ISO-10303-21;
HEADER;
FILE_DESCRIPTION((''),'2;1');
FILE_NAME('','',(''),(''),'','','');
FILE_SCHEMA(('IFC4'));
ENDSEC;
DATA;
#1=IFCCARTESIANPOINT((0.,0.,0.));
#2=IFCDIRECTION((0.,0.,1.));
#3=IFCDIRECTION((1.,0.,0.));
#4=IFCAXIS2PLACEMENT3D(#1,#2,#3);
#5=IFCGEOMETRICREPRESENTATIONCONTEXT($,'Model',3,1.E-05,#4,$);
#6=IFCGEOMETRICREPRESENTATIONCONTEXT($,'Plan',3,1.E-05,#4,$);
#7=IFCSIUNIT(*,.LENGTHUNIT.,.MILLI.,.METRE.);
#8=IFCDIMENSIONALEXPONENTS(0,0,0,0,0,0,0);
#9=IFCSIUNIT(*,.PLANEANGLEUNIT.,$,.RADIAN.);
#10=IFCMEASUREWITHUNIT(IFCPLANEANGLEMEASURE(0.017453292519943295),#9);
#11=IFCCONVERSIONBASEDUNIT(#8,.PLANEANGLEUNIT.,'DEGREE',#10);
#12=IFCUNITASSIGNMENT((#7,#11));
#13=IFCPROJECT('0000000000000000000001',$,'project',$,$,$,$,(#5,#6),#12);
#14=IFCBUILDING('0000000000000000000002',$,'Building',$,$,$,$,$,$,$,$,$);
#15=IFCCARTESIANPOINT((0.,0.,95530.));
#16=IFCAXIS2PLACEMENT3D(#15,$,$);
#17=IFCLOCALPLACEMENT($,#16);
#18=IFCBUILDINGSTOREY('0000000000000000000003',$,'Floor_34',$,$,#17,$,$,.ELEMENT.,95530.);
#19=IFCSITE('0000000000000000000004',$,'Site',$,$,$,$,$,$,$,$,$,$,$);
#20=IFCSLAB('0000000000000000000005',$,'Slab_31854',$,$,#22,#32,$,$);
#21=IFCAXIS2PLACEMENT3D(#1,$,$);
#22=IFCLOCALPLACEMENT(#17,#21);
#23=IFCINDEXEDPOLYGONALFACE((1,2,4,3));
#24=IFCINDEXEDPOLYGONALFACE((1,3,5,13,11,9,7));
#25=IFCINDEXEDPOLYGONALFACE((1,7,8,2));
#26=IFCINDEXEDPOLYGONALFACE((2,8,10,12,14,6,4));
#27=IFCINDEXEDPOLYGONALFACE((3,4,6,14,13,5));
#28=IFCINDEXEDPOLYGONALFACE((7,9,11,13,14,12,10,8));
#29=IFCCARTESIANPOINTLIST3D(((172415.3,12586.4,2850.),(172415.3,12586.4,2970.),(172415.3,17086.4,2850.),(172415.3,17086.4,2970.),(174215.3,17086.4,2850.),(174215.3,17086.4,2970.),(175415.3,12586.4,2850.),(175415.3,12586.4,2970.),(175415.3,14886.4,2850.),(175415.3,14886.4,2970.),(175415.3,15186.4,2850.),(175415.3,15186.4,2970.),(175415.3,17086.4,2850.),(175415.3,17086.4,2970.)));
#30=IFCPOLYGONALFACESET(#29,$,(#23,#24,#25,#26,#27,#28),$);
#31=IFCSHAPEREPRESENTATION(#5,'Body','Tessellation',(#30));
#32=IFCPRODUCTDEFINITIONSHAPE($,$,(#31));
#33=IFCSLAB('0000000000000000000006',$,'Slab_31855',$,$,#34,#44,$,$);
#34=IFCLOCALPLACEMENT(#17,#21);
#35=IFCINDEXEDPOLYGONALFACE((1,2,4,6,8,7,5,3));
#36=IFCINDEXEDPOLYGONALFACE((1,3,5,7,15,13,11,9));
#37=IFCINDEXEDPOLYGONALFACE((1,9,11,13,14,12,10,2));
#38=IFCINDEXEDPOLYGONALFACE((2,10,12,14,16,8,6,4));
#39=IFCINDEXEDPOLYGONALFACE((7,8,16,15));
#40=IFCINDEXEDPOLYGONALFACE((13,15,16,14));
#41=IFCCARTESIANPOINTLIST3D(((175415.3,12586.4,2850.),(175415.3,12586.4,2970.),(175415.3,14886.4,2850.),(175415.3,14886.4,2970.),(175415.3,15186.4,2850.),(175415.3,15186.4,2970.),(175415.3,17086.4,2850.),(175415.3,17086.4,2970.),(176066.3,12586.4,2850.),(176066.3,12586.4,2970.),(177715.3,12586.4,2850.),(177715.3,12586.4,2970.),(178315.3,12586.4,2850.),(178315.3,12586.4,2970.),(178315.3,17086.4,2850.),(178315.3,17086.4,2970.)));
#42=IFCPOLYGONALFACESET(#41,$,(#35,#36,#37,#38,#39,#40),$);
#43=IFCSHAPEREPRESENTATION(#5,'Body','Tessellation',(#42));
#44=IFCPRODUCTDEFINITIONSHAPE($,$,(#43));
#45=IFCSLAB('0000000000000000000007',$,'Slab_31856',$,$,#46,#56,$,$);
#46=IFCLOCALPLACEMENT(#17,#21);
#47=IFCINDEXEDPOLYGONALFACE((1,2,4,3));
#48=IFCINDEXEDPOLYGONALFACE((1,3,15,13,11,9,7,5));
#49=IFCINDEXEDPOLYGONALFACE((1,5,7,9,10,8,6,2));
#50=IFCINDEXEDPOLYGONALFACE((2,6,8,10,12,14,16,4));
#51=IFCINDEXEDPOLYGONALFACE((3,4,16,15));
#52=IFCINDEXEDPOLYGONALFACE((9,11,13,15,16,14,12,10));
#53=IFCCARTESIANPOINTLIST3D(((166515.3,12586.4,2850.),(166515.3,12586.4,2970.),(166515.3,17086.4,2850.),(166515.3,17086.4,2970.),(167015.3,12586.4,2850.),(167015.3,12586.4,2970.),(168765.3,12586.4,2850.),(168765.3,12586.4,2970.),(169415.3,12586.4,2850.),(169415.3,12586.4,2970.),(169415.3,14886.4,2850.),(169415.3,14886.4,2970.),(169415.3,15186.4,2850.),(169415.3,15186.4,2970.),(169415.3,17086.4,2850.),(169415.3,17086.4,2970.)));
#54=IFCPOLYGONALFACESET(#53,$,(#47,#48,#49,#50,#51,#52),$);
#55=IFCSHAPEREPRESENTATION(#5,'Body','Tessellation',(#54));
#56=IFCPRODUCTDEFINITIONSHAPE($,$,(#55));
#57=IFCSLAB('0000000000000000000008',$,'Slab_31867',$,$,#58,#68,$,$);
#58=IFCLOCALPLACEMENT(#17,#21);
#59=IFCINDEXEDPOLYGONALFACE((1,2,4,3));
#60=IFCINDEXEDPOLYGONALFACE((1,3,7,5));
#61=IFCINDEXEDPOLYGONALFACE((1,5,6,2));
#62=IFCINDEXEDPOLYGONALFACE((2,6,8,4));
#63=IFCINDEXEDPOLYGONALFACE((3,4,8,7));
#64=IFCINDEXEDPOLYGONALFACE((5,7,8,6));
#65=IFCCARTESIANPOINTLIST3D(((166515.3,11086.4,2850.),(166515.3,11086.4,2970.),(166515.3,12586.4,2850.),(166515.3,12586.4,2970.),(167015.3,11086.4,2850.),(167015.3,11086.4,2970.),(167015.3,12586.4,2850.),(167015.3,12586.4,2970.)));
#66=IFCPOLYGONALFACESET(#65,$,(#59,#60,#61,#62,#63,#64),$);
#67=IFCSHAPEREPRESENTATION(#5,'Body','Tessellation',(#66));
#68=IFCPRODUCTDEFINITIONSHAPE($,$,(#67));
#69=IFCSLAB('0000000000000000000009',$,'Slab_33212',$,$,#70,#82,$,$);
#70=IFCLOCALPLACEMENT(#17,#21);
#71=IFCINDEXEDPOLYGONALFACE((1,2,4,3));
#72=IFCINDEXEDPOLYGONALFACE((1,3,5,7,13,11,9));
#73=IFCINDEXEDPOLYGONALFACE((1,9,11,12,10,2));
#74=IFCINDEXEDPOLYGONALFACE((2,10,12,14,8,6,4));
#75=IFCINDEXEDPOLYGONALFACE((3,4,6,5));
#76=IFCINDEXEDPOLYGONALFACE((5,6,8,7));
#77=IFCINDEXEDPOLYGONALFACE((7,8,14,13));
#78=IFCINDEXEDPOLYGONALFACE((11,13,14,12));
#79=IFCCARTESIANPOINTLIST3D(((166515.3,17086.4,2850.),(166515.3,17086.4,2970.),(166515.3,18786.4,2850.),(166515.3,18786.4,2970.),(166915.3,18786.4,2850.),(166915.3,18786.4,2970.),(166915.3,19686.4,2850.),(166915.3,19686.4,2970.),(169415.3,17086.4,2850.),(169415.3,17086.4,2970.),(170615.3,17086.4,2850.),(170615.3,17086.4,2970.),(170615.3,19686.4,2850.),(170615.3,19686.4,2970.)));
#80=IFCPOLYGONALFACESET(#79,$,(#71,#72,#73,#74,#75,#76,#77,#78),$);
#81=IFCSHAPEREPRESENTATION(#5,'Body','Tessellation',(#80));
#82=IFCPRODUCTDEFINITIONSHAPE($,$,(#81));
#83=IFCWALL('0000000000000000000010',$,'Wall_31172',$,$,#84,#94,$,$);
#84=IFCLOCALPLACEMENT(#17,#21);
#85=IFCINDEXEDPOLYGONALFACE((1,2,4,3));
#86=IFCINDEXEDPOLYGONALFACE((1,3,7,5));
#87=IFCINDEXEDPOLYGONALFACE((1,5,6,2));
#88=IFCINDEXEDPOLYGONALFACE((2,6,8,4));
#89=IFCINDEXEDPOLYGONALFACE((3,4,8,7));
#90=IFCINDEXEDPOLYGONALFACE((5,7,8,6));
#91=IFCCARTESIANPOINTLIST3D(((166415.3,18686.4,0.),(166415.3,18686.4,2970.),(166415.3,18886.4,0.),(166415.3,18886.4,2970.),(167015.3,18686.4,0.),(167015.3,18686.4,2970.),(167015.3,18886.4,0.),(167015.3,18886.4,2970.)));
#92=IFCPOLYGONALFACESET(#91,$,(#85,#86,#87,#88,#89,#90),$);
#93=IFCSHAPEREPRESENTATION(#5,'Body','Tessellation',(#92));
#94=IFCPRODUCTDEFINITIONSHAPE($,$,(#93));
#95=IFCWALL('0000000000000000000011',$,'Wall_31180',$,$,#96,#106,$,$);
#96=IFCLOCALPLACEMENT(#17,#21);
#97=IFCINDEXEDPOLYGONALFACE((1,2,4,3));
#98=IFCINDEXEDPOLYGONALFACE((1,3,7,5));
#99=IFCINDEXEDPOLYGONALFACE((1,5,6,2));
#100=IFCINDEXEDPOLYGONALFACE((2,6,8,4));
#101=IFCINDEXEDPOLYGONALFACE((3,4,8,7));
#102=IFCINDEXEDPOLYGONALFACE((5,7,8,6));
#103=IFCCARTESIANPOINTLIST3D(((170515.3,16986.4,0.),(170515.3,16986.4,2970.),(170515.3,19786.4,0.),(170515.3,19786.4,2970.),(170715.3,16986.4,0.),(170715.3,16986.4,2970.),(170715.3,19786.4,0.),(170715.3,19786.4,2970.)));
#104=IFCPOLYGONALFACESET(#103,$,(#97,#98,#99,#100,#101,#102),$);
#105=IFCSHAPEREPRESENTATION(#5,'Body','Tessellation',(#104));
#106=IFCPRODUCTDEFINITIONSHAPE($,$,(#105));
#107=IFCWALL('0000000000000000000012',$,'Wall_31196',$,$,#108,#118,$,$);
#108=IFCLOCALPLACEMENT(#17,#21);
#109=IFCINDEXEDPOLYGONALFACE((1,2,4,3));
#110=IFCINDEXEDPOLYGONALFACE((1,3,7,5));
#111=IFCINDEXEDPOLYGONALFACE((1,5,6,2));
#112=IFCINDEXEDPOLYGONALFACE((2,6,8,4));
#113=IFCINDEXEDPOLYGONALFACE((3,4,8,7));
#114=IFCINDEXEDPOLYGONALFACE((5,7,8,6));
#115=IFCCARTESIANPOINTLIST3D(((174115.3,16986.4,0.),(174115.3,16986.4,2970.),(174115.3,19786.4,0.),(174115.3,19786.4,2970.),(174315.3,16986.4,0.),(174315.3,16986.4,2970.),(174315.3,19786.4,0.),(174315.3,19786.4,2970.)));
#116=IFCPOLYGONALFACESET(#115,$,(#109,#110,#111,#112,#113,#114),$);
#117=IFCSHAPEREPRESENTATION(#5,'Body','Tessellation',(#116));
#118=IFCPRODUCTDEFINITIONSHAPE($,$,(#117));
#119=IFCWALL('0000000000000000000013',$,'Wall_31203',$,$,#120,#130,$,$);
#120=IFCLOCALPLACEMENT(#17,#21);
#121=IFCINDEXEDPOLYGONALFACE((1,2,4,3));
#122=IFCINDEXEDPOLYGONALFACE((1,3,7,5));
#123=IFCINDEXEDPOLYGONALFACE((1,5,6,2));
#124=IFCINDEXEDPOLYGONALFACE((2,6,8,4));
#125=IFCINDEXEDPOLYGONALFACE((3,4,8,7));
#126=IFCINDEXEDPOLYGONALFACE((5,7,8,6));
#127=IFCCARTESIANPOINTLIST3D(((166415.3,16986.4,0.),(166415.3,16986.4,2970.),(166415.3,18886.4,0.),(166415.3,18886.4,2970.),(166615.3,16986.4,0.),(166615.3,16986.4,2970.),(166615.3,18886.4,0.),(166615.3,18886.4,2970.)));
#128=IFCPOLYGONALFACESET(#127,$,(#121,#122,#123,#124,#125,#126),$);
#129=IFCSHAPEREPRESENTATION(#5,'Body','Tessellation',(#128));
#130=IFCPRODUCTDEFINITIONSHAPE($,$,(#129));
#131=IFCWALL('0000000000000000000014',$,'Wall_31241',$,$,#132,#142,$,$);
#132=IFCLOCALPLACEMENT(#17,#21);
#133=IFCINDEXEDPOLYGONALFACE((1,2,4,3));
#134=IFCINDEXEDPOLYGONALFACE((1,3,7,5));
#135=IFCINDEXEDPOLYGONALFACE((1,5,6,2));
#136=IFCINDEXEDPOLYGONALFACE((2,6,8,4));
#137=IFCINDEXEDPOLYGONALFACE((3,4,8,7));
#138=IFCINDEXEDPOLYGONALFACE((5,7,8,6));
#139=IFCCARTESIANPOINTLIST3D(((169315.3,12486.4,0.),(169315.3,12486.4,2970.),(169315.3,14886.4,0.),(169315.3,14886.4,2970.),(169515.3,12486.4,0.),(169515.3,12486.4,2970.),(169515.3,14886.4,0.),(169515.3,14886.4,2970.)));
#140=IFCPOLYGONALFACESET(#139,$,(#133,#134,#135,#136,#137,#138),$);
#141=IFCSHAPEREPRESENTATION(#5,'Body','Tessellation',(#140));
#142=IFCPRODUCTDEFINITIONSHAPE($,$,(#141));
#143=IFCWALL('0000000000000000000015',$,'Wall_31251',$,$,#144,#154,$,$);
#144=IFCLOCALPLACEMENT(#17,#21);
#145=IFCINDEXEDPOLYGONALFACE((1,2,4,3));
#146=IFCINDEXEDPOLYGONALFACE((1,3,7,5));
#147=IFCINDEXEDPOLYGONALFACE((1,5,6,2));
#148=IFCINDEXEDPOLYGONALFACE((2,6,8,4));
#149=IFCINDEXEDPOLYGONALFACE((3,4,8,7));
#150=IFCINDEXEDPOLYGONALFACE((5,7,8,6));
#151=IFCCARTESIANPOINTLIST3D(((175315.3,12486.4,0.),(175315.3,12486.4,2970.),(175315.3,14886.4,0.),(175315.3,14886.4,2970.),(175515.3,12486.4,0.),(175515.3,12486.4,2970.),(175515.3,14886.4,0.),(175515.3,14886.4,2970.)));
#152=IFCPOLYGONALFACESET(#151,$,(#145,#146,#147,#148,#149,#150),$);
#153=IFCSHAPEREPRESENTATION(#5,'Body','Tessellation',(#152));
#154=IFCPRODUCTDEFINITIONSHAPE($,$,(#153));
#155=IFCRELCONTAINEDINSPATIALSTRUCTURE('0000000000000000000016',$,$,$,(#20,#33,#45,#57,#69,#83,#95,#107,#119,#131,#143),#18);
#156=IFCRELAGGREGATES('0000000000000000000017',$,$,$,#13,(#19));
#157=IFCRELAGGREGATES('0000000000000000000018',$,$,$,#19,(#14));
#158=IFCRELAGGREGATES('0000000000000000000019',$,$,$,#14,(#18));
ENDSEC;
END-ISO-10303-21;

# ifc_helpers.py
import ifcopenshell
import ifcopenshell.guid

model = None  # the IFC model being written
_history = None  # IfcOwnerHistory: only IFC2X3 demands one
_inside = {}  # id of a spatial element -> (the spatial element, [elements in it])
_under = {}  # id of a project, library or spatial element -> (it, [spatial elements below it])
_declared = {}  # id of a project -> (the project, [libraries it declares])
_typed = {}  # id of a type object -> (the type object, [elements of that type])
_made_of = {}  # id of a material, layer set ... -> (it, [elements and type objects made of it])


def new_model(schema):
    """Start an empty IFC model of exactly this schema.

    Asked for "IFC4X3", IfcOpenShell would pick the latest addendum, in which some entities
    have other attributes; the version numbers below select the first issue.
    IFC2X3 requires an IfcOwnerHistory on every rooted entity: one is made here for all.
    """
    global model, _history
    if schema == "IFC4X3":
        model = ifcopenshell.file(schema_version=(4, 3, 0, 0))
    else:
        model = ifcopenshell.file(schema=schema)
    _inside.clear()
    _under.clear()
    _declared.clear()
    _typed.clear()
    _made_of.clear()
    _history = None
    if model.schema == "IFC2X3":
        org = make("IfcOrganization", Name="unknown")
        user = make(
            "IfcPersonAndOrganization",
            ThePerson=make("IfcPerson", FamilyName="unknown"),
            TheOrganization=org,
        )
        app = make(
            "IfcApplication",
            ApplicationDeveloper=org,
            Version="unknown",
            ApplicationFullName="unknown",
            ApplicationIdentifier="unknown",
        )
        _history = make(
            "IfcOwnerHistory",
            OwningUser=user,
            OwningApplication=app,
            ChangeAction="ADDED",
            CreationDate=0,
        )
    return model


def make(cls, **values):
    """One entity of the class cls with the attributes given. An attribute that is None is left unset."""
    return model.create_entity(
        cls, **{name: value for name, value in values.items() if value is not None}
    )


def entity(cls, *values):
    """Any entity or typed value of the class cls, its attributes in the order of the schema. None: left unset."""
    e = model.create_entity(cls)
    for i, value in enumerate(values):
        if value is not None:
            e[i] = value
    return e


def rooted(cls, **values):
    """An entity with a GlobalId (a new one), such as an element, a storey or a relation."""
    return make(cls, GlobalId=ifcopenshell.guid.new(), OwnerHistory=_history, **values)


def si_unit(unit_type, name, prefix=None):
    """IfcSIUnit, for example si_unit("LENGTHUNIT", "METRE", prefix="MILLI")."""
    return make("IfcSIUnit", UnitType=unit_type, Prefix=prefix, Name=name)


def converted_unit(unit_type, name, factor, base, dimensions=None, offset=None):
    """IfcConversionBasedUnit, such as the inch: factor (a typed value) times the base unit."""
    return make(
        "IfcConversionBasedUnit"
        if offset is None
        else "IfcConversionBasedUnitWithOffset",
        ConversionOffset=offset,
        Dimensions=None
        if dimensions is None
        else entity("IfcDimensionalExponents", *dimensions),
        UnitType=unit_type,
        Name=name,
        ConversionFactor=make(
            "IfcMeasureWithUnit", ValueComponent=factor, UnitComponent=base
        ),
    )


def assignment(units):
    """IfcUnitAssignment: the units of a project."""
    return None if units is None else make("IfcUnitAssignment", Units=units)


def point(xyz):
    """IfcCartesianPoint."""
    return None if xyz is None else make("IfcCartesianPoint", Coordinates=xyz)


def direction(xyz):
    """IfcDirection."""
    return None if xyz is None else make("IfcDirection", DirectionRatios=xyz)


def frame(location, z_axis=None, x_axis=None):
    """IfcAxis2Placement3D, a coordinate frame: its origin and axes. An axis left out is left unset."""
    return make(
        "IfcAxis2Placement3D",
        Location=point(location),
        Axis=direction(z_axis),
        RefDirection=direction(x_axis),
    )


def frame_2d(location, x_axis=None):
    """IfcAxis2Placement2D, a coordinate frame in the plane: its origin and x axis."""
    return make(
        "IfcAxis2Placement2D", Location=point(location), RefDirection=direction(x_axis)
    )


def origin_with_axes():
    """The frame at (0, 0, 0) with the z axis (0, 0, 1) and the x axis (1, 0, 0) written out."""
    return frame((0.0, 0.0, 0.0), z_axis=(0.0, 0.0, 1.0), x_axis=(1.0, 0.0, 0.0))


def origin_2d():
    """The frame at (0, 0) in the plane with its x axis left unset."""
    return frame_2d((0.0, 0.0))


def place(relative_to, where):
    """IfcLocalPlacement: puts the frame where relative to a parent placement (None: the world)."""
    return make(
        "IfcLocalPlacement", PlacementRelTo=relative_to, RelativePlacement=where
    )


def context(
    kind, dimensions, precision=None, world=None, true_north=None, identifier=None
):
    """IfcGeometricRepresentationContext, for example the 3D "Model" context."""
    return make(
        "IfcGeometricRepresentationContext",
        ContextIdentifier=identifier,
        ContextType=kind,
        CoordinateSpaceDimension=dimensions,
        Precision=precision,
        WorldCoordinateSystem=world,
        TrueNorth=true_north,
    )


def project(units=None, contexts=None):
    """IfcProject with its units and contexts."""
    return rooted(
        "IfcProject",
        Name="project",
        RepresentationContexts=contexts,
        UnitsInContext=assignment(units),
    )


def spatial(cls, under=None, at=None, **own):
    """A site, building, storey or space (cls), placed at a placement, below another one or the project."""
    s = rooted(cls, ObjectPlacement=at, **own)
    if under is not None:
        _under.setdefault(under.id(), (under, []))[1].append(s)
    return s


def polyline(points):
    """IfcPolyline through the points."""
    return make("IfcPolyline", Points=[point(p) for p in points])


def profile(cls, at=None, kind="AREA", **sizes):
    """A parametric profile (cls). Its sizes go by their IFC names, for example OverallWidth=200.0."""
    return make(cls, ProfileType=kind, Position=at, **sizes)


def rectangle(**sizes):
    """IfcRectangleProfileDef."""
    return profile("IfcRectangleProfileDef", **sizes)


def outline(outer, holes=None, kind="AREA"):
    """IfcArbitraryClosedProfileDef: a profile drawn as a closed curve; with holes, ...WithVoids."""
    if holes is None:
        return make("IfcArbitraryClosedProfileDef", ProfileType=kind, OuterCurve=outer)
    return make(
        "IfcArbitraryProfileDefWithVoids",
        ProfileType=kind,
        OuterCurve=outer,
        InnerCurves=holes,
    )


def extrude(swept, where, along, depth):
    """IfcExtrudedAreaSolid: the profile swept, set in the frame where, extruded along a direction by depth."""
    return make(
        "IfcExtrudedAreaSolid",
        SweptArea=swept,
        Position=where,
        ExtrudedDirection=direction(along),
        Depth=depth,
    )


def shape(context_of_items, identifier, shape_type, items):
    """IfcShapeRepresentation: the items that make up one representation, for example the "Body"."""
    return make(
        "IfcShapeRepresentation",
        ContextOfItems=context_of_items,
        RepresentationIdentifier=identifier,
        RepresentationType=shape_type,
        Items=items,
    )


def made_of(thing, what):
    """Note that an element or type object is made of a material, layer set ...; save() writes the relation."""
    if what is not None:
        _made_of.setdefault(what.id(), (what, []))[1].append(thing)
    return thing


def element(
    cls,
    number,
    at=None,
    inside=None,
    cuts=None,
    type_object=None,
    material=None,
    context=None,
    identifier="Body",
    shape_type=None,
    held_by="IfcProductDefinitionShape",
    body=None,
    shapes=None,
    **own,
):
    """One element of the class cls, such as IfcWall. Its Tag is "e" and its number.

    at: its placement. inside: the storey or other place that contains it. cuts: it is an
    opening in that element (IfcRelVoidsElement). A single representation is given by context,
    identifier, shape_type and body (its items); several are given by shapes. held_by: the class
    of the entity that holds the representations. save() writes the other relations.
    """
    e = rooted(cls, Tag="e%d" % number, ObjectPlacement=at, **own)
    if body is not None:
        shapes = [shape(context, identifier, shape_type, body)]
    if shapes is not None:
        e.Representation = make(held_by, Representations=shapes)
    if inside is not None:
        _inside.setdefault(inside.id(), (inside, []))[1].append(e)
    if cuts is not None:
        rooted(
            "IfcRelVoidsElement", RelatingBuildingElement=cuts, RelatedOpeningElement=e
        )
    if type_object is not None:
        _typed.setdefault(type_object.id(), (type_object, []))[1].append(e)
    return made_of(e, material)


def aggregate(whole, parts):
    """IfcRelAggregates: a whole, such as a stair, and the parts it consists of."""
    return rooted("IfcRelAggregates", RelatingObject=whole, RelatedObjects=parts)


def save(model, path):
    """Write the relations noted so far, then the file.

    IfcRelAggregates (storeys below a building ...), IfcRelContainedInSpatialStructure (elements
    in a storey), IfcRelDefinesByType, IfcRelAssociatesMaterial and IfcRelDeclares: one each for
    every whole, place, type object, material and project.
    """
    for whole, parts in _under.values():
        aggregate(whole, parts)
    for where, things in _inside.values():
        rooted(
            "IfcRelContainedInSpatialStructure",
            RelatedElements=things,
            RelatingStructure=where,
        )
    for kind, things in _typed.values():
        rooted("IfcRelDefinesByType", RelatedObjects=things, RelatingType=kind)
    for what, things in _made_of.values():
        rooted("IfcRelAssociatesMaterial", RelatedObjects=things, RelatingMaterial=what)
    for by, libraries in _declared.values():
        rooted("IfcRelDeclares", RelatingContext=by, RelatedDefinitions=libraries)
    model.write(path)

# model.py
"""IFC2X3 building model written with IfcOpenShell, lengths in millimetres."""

from ifc_helpers import new_model, entity, si_unit, converted_unit, frame, origin_with_axes, origin_2d, place, context, project, spatial, polyline, rectangle, outline, extrude, element, save


model = new_model("IFC2X3")

# Units and contexts
model_context = context("Model", 3, precision=1e-05, world=origin_with_axes())
plan_context = context("Plan", 3, precision=1e-05, world=origin_with_axes())
ifc_project = project(units=[si_unit("LENGTHUNIT", "METRE", prefix="MILLI"), converted_unit("PLANEANGLEUNIT", "DEGREE", entity("IfcPlaneAngleMeasure", 0.017453292519943295), si_unit("PLANEANGLEUNIT", "RADIAN"), dimensions=[0, 0, 0, 0, 0, 0, 0])], contexts=[model_context, plan_context])

# Site, building, storey
site = spatial("IfcSite", under=ifc_project, Name="Site")
building = spatial("IfcBuilding", under=site, Name="Building")
storey_placement = place(None, frame((0.0, 0.0, 95530.0)))
storey = spatial("IfcBuildingStorey", under=building, at=storey_placement, Name="Floor_34", CompositionType="ELEMENT", Elevation=95530.0)

# Slabs
slab_1_placement = place(storey_placement, frame((172415.3, 17086.4, 2850.0), z_axis=(0.0, 0.0, 1.0), x_axis=(0.0, -4500.031, 0.0)))
element("IfcSlab", 1, at=slab_1_placement, inside=storey, Name="Slab_31854", context=model_context, shape_type="SweptSolid", body=[
    extrude(outline(polyline([(0.0, 0.0), (4500.0, 0.0), (4500.0, 3000.0), (2200.0, 3000.0), (1900.0, 3000.0), (0.0, 3000.0), (0.0, 1800.0)])), origin_with_axes(), (0.0, 0.0, 1.0), 120.0),
])
slab_2_placement = place(storey_placement, frame((175415.3, 17086.4, 2850.0), z_axis=(0.0, 0.0, 1.0), x_axis=(-0.006, -1900.025, 0.0)))
element("IfcSlab", 2, at=slab_2_placement, inside=storey, Name="Slab_31855", context=model_context, shape_type="SweptSolid", body=[
    extrude(outline(polyline([(0.0, 0.0), (1900.0, 0.0), (2200.0, 0.0), (4500.0, 0.0), (4500.0, 651.0), (4500.0, 2300.0), (4500.0, 2900.0), (0.0, 2900.0)])), origin_with_axes(), (0.0, 0.0, 1.0), 120.0),
])
slab_3_placement = place(storey_placement, frame((166515.3, 17086.4, 2850.0), z_axis=(0.0, 0.0, 1.0), x_axis=(0.0, -4500.031, 0.0)))
element("IfcSlab", 3, at=slab_3_placement, inside=storey, Name="Slab_31856", context=model_context, shape_type="SweptSolid", body=[
    extrude(outline(polyline([(0.0, 0.0), (4500.0, 0.0), (4500.0, 500.0), (4500.0, 2250.0), (4500.0, 2900.0), (2200.0, 2900.0), (1900.0, 2900.0), (0.0, 2900.0)])), origin_with_axes(), (0.0, 0.0, 1.0), 120.0),
])
slab_4_placement = place(storey_placement, frame((166515.3, 12586.4, 2850.0), z_axis=(0.0, 0.0, 1.0), x_axis=(0.0, -1500.0, 0.0)))
element("IfcSlab", 4, at=slab_4_placement, inside=storey, Name="Slab_31867", context=model_context, shape_type="SweptSolid", body=[
    extrude(outline(polyline([(0.0, 0.0), (1500.0, 0.0), (1500.0, 500.0), (0.0, 500.0)])), origin_with_axes(), (0.0, 0.0, 1.0), 120.0),
])
slab_5_placement = place(storey_placement, frame((166515.3, 18786.4, 2850.0), z_axis=(0.0, 0.0, 1.0), x_axis=(0.0, -1700.0, 0.0)))
element("IfcSlab", 5, at=slab_5_placement, inside=storey, Name="Slab_33212", context=model_context, shape_type="SweptSolid", body=[
    extrude(outline(polyline([(0.0, 0.0), (1700.0, 0.0), (1700.0, 2900.0), (1700.0, 4100.0), (-900.0, 4100.0), (-900.0, 400.0), (0.0, 400.0)])), origin_with_axes(), (0.0, 0.0, 1.0), 120.0),
])

# Walls
wall_1_placement = place(storey_placement, frame((166715.3, 18786.4, 0.0), z_axis=(0.0, 0.0, 1.0), x_axis=(599.999921, 0.0, 0.0)))
element("IfcWall", 6, at=wall_1_placement, inside=storey, Name="Wall_31172", context=model_context, shape_type="SweptSolid", body=[
    extrude(rectangle(XDim=600.0, YDim=200.0, at=origin_2d()), origin_with_axes(), (0.0, 0.0, 1.0), 2970.0),
])
for number, where, z_axis, x_axis, name in (
    (7, (170615.3, 18386.4, 0.0), (0.0, 0.0, 1.0), (0.0, 2799.990212, 0.0), "Wall_31180"),
    (8, (174215.3, 18386.4, 0.0), (0.0, 0.0, 1.0), (0.0, 2799.990212, 0.0), "Wall_31196"),
):
    element("IfcWall", number, at=place(storey_placement, frame(where, z_axis=z_axis, x_axis=x_axis)), inside=storey, Name=name, context=model_context, shape_type="SweptSolid", body=[
        extrude(rectangle(XDim=2800.0, YDim=200.0, at=origin_2d()), origin_with_axes(), (0.0, 0.0, 1.0), 2970.0),
    ])
wall_2_placement = place(storey_placement, frame((166515.3, 17936.4, 0.0), z_axis=(0.0, 0.0, 1.0), x_axis=(0.0, 1899.999986, 0.0)))
element("IfcWall", 9, at=wall_2_placement, inside=storey, Name="Wall_31203", context=model_context, shape_type="SweptSolid", body=[
    extrude(rectangle(XDim=1900.0, YDim=200.0, at=origin_2d()), origin_with_axes(), (0.0, 0.0, 1.0), 2970.0),
])
wall_3_placement = place(storey_placement, frame((169415.3, 13686.4, 0.0), z_axis=(0.0, 0.0, 1.0), x_axis=(-0.000001, 2400.0, 0.0)))
element("IfcWall", 10, at=wall_3_placement, inside=storey, Name="Wall_31241", context=model_context, shape_type="SweptSolid", body=[
    extrude(rectangle(XDim=2400.0, YDim=200.0, at=origin_2d()), origin_with_axes(), (0.0, 0.0, 1.0), 2970.0),
])
wall_4_placement = place(storey_placement, frame((175415.3, 13686.4, 0.0), z_axis=(0.0, 0.0, 1.0), x_axis=(0.0, 2400.0, 0.0)))
element("IfcWall", 11, at=wall_4_placement, inside=storey, Name="Wall_31251", context=model_context, shape_type="SweptSolid", body=[
    extrude(rectangle(XDim=2400.0, YDim=200.0, at=origin_2d()), origin_with_axes(), (0.0, 0.0, 1.0), 2970.0),
])

save(model, "model.ifc")
